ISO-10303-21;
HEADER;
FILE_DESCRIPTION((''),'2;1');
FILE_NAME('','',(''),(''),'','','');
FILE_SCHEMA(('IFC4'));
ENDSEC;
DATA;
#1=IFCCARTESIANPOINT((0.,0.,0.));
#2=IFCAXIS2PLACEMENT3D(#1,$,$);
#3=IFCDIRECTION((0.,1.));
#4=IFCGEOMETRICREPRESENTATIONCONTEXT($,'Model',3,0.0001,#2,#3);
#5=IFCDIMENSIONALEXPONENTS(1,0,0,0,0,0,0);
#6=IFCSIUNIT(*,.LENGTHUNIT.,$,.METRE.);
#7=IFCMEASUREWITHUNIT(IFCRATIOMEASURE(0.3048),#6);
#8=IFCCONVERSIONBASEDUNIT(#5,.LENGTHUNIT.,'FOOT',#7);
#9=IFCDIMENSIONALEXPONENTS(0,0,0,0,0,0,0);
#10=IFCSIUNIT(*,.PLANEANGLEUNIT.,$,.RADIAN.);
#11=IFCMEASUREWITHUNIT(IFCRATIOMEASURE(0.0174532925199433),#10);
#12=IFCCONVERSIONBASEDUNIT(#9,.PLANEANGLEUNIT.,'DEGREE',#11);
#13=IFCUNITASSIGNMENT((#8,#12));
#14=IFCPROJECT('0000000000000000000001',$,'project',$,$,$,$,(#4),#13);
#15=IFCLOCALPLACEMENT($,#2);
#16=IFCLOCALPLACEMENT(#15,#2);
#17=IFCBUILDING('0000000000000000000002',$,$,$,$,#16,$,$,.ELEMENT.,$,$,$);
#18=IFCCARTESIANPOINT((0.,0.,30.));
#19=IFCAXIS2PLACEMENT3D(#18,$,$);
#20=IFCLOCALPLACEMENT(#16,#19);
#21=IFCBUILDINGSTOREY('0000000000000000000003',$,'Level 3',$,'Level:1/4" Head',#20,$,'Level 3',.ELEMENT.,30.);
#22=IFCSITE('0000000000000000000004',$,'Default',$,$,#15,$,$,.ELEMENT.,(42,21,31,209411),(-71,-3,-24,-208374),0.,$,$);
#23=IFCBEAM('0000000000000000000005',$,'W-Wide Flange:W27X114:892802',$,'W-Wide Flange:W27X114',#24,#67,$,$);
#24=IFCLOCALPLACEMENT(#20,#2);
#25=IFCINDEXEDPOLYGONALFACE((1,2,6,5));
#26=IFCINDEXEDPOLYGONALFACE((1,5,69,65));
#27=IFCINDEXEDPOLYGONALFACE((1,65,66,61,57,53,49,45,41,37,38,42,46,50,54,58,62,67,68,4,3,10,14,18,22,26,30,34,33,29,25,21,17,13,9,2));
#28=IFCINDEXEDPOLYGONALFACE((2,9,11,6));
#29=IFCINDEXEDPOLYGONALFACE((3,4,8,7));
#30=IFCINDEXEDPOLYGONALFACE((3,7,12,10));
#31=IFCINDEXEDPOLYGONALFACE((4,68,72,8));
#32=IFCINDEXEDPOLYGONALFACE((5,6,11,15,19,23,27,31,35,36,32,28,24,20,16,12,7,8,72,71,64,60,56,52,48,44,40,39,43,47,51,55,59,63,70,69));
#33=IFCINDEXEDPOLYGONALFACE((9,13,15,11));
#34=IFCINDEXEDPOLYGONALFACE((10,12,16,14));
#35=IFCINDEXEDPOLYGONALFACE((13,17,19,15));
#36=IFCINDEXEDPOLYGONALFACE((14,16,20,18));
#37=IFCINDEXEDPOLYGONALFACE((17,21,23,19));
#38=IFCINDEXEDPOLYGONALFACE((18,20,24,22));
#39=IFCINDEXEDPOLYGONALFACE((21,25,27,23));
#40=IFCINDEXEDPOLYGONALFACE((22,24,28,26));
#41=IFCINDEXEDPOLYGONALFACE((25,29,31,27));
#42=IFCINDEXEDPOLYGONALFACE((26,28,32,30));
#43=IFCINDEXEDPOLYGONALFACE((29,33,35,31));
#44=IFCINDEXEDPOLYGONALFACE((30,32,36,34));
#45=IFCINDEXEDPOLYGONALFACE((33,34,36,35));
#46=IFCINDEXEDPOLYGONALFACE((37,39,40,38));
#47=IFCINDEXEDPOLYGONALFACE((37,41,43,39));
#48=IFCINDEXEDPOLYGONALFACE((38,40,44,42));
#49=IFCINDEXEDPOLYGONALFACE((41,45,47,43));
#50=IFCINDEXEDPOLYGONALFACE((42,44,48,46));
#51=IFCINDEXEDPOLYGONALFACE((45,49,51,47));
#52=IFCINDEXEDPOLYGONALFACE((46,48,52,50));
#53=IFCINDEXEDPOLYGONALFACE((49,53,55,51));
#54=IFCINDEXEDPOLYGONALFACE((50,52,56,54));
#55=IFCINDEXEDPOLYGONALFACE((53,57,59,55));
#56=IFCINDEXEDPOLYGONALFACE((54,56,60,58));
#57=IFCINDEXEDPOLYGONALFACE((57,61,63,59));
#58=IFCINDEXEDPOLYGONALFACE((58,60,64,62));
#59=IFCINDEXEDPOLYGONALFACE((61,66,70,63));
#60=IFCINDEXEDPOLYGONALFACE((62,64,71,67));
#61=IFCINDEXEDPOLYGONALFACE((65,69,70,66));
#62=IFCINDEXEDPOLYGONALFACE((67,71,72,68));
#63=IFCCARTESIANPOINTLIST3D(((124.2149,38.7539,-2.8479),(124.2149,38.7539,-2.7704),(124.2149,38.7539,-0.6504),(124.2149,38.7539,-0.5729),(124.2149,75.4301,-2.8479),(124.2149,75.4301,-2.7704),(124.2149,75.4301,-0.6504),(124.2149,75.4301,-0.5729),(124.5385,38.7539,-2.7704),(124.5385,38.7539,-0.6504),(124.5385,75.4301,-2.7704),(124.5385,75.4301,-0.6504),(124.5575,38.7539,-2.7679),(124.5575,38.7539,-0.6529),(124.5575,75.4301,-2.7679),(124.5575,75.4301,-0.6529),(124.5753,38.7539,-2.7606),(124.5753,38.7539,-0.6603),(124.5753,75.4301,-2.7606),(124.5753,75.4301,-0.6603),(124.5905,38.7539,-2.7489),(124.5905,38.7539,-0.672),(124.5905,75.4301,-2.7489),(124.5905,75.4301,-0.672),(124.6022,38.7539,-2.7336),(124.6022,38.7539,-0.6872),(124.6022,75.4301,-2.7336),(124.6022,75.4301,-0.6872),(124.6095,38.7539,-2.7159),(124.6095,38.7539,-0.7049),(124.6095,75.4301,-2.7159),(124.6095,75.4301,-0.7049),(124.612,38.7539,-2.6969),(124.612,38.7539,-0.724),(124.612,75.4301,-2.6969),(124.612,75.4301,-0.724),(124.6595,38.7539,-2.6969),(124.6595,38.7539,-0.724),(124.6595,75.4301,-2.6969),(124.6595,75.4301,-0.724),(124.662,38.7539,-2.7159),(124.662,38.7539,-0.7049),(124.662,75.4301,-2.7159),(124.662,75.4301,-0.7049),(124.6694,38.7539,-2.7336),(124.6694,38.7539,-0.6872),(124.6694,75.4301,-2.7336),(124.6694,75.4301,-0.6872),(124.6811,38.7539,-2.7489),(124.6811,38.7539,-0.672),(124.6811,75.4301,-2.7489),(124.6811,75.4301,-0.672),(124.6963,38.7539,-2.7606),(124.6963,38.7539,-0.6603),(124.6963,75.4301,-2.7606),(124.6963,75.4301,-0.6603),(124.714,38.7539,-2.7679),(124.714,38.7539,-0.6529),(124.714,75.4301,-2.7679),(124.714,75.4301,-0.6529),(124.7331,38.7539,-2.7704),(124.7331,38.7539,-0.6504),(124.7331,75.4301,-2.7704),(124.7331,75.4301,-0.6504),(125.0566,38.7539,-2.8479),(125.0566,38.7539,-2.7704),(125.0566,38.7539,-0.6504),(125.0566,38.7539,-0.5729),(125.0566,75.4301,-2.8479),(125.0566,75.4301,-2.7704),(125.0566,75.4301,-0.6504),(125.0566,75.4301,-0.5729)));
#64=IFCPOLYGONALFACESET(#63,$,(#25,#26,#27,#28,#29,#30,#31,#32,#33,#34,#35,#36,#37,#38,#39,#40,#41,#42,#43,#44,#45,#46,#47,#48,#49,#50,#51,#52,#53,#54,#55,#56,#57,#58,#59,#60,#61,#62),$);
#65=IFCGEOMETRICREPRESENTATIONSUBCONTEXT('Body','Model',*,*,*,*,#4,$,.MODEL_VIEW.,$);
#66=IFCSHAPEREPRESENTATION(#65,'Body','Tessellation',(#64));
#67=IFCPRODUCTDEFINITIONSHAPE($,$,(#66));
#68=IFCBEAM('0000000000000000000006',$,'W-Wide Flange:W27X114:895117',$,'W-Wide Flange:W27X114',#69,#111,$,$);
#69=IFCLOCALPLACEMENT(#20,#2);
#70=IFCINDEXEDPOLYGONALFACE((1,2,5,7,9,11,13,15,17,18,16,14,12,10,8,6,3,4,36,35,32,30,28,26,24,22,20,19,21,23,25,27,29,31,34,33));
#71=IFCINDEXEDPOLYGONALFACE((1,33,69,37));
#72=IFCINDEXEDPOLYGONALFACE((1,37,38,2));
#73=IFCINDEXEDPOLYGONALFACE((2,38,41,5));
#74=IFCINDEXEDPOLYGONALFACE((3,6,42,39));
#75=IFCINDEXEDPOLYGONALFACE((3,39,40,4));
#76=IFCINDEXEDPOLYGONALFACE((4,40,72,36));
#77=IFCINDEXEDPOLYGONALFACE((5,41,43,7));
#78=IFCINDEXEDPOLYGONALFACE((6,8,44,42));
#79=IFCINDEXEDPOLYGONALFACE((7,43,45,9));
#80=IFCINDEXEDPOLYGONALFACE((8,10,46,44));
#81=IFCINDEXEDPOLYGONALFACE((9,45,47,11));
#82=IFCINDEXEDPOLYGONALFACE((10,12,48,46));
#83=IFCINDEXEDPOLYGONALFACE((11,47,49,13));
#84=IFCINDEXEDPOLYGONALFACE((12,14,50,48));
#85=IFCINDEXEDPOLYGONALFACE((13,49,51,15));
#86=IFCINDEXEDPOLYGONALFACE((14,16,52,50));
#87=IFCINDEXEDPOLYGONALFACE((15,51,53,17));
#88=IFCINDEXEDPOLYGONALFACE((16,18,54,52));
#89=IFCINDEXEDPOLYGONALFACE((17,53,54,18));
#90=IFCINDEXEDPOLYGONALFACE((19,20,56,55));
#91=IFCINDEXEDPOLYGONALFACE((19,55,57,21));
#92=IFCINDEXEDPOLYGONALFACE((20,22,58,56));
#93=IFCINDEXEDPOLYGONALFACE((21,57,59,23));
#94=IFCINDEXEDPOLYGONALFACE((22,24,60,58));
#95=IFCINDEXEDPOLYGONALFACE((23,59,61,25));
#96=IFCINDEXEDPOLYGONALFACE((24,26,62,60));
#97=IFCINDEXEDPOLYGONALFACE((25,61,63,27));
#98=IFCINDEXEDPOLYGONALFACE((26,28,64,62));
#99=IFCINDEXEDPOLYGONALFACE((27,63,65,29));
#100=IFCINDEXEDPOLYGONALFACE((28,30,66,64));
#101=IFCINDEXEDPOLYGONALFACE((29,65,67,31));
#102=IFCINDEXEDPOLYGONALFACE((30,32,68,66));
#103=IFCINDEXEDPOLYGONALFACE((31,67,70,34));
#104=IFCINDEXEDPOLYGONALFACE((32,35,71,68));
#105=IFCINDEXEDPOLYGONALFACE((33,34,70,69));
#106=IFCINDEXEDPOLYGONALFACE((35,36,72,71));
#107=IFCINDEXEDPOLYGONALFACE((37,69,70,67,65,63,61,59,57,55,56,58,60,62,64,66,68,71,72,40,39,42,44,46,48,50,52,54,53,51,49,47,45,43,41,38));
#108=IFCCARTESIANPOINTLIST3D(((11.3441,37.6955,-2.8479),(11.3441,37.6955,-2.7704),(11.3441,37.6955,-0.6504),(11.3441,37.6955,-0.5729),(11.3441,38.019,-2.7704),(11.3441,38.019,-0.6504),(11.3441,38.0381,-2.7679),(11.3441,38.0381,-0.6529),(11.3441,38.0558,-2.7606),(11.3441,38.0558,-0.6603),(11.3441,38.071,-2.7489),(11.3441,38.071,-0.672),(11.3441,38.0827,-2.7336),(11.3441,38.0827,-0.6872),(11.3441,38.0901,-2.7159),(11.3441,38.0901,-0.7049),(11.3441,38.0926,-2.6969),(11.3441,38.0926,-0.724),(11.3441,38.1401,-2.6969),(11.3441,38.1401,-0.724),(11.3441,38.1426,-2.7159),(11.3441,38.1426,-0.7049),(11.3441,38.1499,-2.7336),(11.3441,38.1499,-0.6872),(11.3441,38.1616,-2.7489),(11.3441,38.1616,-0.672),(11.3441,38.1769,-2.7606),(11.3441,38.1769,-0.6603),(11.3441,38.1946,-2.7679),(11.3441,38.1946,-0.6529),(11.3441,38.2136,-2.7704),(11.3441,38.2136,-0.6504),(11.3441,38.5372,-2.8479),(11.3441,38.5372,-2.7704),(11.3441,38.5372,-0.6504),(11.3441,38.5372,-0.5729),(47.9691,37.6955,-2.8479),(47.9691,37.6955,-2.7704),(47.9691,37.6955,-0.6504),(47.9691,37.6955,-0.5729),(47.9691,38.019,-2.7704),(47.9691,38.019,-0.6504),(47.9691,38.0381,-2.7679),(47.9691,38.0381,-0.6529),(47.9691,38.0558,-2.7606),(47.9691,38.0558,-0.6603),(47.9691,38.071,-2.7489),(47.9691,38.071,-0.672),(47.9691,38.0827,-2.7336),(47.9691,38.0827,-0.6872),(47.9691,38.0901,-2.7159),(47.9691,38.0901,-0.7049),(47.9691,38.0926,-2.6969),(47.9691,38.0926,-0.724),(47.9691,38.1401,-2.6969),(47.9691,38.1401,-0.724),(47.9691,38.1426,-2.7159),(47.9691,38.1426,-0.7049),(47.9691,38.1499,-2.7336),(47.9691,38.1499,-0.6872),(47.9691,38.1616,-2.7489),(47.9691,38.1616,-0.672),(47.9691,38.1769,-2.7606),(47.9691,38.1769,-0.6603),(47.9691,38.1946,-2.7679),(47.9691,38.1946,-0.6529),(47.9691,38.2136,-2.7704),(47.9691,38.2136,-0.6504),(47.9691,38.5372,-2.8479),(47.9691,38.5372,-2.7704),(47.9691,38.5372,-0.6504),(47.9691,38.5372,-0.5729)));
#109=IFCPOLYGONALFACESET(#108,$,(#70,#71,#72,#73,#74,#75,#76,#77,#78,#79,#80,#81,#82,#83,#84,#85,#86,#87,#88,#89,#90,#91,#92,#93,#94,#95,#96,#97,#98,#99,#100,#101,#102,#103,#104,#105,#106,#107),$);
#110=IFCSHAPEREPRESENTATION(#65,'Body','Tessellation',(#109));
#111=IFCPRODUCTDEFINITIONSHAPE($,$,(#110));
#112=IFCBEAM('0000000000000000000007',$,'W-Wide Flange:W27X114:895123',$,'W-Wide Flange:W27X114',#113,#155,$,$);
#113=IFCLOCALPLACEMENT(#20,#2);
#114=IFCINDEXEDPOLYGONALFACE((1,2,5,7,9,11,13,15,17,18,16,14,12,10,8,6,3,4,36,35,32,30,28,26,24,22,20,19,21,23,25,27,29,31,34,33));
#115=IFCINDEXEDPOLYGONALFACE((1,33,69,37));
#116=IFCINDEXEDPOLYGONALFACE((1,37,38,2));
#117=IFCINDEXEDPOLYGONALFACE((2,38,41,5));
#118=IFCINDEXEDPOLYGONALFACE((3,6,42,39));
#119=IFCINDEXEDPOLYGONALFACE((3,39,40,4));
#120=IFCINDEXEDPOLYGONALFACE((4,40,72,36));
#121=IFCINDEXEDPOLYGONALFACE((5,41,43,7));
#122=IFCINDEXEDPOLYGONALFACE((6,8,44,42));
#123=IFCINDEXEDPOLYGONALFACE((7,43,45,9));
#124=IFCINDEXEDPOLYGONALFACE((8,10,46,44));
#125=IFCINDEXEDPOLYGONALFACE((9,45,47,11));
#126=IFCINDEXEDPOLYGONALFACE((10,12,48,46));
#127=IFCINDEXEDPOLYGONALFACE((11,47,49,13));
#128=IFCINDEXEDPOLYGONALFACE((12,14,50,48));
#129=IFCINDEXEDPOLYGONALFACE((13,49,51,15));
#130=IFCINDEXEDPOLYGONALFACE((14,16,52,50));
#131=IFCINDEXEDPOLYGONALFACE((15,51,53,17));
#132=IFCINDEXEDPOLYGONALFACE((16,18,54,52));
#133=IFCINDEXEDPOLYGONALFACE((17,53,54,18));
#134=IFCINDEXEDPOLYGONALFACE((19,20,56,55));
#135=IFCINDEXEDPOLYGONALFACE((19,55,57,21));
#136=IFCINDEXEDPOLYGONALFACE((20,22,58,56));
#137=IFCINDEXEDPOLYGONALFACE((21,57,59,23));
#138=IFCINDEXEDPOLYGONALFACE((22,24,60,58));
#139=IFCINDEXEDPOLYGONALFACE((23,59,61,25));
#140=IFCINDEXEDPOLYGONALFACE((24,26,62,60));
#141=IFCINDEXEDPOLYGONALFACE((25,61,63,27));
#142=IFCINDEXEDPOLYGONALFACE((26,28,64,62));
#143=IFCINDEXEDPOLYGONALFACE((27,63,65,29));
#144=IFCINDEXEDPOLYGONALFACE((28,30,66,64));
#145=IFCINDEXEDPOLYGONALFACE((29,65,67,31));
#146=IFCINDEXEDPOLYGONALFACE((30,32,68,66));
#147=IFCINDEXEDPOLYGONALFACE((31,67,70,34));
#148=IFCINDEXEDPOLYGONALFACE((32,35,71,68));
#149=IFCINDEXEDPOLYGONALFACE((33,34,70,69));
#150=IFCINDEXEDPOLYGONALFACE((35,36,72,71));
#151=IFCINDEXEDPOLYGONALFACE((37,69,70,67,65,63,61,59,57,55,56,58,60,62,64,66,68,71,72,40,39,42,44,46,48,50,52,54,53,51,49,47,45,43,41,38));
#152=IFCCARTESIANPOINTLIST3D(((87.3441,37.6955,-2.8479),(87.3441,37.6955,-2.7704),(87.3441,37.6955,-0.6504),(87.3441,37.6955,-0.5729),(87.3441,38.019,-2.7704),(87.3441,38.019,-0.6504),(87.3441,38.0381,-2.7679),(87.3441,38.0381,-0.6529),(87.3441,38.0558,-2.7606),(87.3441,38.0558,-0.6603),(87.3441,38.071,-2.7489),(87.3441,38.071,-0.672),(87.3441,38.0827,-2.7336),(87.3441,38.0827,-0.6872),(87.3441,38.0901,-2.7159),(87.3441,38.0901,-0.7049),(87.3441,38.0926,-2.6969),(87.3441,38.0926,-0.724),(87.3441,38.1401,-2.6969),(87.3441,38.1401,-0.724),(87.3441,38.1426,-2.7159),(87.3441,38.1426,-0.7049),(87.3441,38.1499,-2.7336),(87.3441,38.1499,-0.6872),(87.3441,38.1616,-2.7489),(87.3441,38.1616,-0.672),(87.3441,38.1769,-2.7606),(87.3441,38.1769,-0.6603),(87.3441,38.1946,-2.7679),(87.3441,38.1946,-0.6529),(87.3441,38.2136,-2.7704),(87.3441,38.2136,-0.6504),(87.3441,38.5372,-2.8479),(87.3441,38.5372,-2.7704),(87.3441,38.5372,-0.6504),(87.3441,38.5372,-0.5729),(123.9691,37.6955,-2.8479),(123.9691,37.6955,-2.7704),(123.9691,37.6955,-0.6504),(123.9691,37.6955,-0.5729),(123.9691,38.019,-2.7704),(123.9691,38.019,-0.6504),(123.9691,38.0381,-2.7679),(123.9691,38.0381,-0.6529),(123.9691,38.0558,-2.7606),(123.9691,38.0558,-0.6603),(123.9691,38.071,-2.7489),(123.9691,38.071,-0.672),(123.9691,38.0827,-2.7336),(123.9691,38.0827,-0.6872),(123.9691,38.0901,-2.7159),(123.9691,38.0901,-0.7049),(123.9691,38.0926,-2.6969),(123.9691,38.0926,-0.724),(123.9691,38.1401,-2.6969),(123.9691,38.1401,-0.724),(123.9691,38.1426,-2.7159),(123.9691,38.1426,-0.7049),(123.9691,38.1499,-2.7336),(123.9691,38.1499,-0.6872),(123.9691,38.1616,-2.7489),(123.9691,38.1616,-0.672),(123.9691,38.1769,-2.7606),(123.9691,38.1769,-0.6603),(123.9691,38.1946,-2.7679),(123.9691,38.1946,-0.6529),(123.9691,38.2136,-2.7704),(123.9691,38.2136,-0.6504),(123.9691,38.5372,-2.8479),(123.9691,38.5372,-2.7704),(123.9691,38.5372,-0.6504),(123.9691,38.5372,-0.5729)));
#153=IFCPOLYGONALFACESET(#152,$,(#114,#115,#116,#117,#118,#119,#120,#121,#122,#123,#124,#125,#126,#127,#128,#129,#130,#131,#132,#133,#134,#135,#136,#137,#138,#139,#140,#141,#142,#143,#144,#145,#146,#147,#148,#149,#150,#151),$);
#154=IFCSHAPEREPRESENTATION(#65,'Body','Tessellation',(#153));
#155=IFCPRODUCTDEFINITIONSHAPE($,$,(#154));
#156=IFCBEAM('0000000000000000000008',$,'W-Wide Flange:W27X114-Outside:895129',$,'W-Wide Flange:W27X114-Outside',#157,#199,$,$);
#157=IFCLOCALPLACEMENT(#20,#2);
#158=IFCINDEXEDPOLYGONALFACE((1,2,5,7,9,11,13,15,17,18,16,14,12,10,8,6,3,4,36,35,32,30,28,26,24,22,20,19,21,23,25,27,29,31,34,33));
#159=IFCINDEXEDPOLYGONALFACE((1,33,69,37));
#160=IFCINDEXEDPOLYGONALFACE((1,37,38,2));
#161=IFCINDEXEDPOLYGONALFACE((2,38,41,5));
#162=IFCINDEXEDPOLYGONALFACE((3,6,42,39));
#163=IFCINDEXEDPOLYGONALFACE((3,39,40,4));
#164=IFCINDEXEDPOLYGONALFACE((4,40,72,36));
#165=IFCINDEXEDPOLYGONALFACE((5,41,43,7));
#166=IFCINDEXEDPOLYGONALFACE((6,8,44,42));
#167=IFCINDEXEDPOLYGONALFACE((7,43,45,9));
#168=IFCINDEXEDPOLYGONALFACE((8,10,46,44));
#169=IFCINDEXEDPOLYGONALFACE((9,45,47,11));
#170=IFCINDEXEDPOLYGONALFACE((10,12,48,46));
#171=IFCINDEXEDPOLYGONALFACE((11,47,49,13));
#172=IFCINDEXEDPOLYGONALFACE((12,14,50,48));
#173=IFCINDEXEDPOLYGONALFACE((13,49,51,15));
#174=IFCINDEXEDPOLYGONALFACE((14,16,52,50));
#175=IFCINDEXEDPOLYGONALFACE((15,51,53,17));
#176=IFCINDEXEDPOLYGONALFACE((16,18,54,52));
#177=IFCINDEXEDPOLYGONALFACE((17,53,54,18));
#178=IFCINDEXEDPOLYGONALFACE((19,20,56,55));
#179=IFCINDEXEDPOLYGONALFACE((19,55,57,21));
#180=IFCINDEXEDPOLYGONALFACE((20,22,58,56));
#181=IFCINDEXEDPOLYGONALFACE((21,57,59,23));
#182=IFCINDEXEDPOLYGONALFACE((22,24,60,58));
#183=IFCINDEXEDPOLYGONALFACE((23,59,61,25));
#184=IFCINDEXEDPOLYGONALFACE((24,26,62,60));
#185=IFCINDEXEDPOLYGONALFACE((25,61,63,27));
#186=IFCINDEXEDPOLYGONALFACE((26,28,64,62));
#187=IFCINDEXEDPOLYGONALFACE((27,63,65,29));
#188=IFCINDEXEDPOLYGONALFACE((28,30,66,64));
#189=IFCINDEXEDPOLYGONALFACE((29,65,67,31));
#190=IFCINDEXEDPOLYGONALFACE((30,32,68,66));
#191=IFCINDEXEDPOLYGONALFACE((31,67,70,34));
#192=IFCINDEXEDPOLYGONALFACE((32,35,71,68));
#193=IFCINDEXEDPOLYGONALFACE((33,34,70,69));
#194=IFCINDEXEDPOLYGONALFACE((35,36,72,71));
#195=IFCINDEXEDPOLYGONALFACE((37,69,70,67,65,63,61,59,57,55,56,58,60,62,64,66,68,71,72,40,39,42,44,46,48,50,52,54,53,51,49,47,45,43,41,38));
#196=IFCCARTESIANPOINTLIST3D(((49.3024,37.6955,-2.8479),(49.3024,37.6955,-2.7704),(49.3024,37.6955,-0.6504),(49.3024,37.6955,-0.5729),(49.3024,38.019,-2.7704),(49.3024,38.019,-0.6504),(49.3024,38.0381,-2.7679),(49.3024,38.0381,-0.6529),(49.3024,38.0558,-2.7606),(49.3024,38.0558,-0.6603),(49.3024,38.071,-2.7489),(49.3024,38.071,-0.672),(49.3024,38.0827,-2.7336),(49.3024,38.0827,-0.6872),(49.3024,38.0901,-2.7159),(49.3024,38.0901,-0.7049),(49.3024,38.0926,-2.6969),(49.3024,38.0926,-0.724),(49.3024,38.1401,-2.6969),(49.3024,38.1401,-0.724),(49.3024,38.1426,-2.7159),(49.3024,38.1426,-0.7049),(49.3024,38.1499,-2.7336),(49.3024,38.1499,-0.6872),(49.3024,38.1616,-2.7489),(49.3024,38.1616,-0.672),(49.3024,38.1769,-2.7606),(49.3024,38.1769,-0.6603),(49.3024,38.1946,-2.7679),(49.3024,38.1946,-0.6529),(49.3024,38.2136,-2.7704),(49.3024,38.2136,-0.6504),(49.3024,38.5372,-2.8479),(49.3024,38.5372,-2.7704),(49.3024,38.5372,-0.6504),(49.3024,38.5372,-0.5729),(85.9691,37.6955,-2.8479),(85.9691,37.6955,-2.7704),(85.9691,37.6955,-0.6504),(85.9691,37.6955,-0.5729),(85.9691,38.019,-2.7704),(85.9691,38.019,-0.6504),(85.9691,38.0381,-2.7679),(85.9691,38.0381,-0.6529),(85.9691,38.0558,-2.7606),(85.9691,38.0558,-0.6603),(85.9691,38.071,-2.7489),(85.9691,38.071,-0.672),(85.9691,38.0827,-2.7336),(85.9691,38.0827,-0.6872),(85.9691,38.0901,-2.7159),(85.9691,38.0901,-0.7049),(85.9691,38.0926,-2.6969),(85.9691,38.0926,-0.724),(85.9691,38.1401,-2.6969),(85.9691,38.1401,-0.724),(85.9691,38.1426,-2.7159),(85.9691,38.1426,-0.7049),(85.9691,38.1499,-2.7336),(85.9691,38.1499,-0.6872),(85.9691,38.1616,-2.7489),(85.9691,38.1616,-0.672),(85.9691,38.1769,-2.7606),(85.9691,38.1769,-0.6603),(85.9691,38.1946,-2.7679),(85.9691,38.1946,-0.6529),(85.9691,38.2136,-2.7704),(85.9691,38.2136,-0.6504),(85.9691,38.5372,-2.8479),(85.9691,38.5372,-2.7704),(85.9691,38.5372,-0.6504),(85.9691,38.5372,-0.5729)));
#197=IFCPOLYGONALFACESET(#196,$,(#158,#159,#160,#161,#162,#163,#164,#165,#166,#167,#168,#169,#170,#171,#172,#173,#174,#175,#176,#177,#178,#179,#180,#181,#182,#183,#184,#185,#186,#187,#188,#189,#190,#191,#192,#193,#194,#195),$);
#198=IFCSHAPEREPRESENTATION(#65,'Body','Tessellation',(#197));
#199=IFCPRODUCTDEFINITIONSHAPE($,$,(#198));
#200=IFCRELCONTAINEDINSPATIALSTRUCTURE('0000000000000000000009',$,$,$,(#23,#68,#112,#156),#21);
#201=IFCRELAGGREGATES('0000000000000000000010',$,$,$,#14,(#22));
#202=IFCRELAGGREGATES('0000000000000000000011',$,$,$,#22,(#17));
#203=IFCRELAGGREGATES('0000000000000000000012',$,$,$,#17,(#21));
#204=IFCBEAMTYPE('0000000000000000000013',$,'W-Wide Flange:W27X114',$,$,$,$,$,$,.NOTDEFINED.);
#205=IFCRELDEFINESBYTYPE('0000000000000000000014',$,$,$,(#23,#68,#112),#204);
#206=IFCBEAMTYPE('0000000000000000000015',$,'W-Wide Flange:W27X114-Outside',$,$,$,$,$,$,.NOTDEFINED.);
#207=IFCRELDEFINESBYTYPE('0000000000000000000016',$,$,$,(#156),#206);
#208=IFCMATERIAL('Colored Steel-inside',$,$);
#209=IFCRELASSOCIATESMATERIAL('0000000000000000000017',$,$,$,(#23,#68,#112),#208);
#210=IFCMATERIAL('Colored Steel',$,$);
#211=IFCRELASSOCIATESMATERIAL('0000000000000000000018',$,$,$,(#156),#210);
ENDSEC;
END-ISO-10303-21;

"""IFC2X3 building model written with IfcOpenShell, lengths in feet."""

from ifc_helpers import new_model, entity, si_unit, converted_unit, direction, frame, frame_2d, origin, place, context, subcontext, project, spatial, i_section, extrude, material, type_object, element, save


model = new_model("IFC2X3")

# Units and contexts
model_context = context("Model", 3, precision=0.0001, world=origin(), true_north=direction((0.0, 1.0)))
body_context = subcontext(model_context, "Body", "Model", "MODEL_VIEW")
ifc_project = project(units=[converted_unit("LENGTHUNIT", "FOOT", entity("IfcRatioMeasure", 0.3048), si_unit("LENGTHUNIT", "METRE"), dimensions=[1, 0, 0, 0, 0, 0, 0]), converted_unit("PLANEANGLEUNIT", "DEGREE", entity("IfcRatioMeasure", 0.0174532925199433), si_unit("PLANEANGLEUNIT", "RADIAN"), dimensions=[0, 0, 0, 0, 0, 0, 0])], contexts=[model_context])

# Site, building, storey
site_placement = place(None, origin())
site = spatial("IfcSite", under=ifc_project, at=site_placement, Name="Default", CompositionType="ELEMENT", RefLatitude=(42, 21, 31, 209411), RefLongitude=(-71, -3, -24, -208374), RefElevation=0.0)
building_placement = place(site_placement, origin())
building = spatial("IfcBuilding", under=site, at=building_placement, CompositionType="ELEMENT")
storey_placement = place(building_placement, frame((0.0, 0.0, 30.0)))
storey = spatial("IfcBuildingStorey", under=building, at=storey_placement, Name="Level 3", ObjectType="Level:1/4\" Head", LongName="Level 3", CompositionType="ELEMENT", Elevation=30.0)

# Beams
ifc_material_1 = material(Name="Colored Steel-inside")
beam_type_1 = type_object("IfcBeamType", Name="W-Wide Flange:W27X114", PredefinedType="NOTDEFINED")
beam_1_placement = place(storey_placement, frame((124.6358, 76.0968, 0.0), z_axis=(0.0, 0.0, 1.0), x_axis=(0.0, -1.0, 0.0)))
element("IfcBeam", 1, at=beam_1_placement, inside=storey, type_object=beam_type_1, material=ifc_material_1, Name="W-Wide Flange:W27X114:892802", ObjectType="W-Wide Flange:W27X114", context=body_context, shape_type="SweptSolid", body=[
    extrude(i_section(OverallWidth=0.8417, OverallDepth=2.275, WebThickness=0.0475, FlangeThickness=0.0775, FilletRadius=0.0735, at=frame_2d((0.0, 0.0), x_axis=(0.0, 1.0))), frame((0.6667, 0.0, -1.7104), z_axis=(1.0, 0.0, 0.0), x_axis=(0.0, 0.0, -1.0)), (0.0, 0.0, 1.0), 36.6762),
])
beam_2_placement = place(storey_placement, frame((10.6358, 38.1163, 0.0)))
element("IfcBeam", 2, at=beam_2_placement, inside=storey, type_object=beam_type_1, material=ifc_material_1, Name="W-Wide Flange:W27X114:895117", ObjectType="W-Wide Flange:W27X114", context=body_context, shape_type="SweptSolid", body=[
    extrude(i_section(OverallWidth=0.8417, OverallDepth=2.275, WebThickness=0.0475, FlangeThickness=0.0775, FilletRadius=0.0735, at=frame_2d((0.0, 0.0), x_axis=(0.0, 1.0))), frame((0.7083, 0.0, -1.7104), z_axis=(1.0, 0.0, 0.0), x_axis=(0.0, 0.0, -1.0)), (0.0, 0.0, 1.0), 36.625),
])
beam_3_placement = place(storey_placement, frame((86.6358, 38.1163, 0.0)))
element("IfcBeam", 3, at=beam_3_placement, inside=storey, type_object=beam_type_1, material=ifc_material_1, Name="W-Wide Flange:W27X114:895123", ObjectType="W-Wide Flange:W27X114", context=body_context, shape_type="SweptSolid", body=[
    extrude(i_section(OverallWidth=0.8417, OverallDepth=2.275, WebThickness=0.0475, FlangeThickness=0.0775, FilletRadius=0.0735, at=frame_2d((0.0, 0.0), x_axis=(0.0, 1.0))), frame((0.7083, 0.0, -1.7104), z_axis=(1.0, 0.0, 0.0), x_axis=(0.0, 0.0, -1.0)), (0.0, 0.0, 1.0), 36.625),
])
ifc_material_2 = material(Name="Colored Steel")
beam_type_2 = type_object("IfcBeamType", Name="W-Wide Flange:W27X114-Outside", PredefinedType="NOTDEFINED")
beam_4_placement = place(storey_placement, frame((48.6358, 38.1163, 0.0)))
element("IfcBeam", 4, at=beam_4_placement, inside=storey, type_object=beam_type_2, material=ifc_material_2, Name="W-Wide Flange:W27X114-Outside:895129", ObjectType="W-Wide Flange:W27X114-Outside", context=body_context, shape_type="SweptSolid", body=[
    extrude(i_section(OverallWidth=0.8417, OverallDepth=2.275, WebThickness=0.0475, FlangeThickness=0.0775, FilletRadius=0.0735, at=frame_2d((0.0, 0.0), x_axis=(0.0, 1.0))), frame((0.6667, 0.0, -1.7104), z_axis=(1.0, 0.0, 0.0), x_axis=(0.0, 0.0, -1.0)), (0.0, 0.0, 1.0), 36.6667),
])

save(model, "model.ifc")
